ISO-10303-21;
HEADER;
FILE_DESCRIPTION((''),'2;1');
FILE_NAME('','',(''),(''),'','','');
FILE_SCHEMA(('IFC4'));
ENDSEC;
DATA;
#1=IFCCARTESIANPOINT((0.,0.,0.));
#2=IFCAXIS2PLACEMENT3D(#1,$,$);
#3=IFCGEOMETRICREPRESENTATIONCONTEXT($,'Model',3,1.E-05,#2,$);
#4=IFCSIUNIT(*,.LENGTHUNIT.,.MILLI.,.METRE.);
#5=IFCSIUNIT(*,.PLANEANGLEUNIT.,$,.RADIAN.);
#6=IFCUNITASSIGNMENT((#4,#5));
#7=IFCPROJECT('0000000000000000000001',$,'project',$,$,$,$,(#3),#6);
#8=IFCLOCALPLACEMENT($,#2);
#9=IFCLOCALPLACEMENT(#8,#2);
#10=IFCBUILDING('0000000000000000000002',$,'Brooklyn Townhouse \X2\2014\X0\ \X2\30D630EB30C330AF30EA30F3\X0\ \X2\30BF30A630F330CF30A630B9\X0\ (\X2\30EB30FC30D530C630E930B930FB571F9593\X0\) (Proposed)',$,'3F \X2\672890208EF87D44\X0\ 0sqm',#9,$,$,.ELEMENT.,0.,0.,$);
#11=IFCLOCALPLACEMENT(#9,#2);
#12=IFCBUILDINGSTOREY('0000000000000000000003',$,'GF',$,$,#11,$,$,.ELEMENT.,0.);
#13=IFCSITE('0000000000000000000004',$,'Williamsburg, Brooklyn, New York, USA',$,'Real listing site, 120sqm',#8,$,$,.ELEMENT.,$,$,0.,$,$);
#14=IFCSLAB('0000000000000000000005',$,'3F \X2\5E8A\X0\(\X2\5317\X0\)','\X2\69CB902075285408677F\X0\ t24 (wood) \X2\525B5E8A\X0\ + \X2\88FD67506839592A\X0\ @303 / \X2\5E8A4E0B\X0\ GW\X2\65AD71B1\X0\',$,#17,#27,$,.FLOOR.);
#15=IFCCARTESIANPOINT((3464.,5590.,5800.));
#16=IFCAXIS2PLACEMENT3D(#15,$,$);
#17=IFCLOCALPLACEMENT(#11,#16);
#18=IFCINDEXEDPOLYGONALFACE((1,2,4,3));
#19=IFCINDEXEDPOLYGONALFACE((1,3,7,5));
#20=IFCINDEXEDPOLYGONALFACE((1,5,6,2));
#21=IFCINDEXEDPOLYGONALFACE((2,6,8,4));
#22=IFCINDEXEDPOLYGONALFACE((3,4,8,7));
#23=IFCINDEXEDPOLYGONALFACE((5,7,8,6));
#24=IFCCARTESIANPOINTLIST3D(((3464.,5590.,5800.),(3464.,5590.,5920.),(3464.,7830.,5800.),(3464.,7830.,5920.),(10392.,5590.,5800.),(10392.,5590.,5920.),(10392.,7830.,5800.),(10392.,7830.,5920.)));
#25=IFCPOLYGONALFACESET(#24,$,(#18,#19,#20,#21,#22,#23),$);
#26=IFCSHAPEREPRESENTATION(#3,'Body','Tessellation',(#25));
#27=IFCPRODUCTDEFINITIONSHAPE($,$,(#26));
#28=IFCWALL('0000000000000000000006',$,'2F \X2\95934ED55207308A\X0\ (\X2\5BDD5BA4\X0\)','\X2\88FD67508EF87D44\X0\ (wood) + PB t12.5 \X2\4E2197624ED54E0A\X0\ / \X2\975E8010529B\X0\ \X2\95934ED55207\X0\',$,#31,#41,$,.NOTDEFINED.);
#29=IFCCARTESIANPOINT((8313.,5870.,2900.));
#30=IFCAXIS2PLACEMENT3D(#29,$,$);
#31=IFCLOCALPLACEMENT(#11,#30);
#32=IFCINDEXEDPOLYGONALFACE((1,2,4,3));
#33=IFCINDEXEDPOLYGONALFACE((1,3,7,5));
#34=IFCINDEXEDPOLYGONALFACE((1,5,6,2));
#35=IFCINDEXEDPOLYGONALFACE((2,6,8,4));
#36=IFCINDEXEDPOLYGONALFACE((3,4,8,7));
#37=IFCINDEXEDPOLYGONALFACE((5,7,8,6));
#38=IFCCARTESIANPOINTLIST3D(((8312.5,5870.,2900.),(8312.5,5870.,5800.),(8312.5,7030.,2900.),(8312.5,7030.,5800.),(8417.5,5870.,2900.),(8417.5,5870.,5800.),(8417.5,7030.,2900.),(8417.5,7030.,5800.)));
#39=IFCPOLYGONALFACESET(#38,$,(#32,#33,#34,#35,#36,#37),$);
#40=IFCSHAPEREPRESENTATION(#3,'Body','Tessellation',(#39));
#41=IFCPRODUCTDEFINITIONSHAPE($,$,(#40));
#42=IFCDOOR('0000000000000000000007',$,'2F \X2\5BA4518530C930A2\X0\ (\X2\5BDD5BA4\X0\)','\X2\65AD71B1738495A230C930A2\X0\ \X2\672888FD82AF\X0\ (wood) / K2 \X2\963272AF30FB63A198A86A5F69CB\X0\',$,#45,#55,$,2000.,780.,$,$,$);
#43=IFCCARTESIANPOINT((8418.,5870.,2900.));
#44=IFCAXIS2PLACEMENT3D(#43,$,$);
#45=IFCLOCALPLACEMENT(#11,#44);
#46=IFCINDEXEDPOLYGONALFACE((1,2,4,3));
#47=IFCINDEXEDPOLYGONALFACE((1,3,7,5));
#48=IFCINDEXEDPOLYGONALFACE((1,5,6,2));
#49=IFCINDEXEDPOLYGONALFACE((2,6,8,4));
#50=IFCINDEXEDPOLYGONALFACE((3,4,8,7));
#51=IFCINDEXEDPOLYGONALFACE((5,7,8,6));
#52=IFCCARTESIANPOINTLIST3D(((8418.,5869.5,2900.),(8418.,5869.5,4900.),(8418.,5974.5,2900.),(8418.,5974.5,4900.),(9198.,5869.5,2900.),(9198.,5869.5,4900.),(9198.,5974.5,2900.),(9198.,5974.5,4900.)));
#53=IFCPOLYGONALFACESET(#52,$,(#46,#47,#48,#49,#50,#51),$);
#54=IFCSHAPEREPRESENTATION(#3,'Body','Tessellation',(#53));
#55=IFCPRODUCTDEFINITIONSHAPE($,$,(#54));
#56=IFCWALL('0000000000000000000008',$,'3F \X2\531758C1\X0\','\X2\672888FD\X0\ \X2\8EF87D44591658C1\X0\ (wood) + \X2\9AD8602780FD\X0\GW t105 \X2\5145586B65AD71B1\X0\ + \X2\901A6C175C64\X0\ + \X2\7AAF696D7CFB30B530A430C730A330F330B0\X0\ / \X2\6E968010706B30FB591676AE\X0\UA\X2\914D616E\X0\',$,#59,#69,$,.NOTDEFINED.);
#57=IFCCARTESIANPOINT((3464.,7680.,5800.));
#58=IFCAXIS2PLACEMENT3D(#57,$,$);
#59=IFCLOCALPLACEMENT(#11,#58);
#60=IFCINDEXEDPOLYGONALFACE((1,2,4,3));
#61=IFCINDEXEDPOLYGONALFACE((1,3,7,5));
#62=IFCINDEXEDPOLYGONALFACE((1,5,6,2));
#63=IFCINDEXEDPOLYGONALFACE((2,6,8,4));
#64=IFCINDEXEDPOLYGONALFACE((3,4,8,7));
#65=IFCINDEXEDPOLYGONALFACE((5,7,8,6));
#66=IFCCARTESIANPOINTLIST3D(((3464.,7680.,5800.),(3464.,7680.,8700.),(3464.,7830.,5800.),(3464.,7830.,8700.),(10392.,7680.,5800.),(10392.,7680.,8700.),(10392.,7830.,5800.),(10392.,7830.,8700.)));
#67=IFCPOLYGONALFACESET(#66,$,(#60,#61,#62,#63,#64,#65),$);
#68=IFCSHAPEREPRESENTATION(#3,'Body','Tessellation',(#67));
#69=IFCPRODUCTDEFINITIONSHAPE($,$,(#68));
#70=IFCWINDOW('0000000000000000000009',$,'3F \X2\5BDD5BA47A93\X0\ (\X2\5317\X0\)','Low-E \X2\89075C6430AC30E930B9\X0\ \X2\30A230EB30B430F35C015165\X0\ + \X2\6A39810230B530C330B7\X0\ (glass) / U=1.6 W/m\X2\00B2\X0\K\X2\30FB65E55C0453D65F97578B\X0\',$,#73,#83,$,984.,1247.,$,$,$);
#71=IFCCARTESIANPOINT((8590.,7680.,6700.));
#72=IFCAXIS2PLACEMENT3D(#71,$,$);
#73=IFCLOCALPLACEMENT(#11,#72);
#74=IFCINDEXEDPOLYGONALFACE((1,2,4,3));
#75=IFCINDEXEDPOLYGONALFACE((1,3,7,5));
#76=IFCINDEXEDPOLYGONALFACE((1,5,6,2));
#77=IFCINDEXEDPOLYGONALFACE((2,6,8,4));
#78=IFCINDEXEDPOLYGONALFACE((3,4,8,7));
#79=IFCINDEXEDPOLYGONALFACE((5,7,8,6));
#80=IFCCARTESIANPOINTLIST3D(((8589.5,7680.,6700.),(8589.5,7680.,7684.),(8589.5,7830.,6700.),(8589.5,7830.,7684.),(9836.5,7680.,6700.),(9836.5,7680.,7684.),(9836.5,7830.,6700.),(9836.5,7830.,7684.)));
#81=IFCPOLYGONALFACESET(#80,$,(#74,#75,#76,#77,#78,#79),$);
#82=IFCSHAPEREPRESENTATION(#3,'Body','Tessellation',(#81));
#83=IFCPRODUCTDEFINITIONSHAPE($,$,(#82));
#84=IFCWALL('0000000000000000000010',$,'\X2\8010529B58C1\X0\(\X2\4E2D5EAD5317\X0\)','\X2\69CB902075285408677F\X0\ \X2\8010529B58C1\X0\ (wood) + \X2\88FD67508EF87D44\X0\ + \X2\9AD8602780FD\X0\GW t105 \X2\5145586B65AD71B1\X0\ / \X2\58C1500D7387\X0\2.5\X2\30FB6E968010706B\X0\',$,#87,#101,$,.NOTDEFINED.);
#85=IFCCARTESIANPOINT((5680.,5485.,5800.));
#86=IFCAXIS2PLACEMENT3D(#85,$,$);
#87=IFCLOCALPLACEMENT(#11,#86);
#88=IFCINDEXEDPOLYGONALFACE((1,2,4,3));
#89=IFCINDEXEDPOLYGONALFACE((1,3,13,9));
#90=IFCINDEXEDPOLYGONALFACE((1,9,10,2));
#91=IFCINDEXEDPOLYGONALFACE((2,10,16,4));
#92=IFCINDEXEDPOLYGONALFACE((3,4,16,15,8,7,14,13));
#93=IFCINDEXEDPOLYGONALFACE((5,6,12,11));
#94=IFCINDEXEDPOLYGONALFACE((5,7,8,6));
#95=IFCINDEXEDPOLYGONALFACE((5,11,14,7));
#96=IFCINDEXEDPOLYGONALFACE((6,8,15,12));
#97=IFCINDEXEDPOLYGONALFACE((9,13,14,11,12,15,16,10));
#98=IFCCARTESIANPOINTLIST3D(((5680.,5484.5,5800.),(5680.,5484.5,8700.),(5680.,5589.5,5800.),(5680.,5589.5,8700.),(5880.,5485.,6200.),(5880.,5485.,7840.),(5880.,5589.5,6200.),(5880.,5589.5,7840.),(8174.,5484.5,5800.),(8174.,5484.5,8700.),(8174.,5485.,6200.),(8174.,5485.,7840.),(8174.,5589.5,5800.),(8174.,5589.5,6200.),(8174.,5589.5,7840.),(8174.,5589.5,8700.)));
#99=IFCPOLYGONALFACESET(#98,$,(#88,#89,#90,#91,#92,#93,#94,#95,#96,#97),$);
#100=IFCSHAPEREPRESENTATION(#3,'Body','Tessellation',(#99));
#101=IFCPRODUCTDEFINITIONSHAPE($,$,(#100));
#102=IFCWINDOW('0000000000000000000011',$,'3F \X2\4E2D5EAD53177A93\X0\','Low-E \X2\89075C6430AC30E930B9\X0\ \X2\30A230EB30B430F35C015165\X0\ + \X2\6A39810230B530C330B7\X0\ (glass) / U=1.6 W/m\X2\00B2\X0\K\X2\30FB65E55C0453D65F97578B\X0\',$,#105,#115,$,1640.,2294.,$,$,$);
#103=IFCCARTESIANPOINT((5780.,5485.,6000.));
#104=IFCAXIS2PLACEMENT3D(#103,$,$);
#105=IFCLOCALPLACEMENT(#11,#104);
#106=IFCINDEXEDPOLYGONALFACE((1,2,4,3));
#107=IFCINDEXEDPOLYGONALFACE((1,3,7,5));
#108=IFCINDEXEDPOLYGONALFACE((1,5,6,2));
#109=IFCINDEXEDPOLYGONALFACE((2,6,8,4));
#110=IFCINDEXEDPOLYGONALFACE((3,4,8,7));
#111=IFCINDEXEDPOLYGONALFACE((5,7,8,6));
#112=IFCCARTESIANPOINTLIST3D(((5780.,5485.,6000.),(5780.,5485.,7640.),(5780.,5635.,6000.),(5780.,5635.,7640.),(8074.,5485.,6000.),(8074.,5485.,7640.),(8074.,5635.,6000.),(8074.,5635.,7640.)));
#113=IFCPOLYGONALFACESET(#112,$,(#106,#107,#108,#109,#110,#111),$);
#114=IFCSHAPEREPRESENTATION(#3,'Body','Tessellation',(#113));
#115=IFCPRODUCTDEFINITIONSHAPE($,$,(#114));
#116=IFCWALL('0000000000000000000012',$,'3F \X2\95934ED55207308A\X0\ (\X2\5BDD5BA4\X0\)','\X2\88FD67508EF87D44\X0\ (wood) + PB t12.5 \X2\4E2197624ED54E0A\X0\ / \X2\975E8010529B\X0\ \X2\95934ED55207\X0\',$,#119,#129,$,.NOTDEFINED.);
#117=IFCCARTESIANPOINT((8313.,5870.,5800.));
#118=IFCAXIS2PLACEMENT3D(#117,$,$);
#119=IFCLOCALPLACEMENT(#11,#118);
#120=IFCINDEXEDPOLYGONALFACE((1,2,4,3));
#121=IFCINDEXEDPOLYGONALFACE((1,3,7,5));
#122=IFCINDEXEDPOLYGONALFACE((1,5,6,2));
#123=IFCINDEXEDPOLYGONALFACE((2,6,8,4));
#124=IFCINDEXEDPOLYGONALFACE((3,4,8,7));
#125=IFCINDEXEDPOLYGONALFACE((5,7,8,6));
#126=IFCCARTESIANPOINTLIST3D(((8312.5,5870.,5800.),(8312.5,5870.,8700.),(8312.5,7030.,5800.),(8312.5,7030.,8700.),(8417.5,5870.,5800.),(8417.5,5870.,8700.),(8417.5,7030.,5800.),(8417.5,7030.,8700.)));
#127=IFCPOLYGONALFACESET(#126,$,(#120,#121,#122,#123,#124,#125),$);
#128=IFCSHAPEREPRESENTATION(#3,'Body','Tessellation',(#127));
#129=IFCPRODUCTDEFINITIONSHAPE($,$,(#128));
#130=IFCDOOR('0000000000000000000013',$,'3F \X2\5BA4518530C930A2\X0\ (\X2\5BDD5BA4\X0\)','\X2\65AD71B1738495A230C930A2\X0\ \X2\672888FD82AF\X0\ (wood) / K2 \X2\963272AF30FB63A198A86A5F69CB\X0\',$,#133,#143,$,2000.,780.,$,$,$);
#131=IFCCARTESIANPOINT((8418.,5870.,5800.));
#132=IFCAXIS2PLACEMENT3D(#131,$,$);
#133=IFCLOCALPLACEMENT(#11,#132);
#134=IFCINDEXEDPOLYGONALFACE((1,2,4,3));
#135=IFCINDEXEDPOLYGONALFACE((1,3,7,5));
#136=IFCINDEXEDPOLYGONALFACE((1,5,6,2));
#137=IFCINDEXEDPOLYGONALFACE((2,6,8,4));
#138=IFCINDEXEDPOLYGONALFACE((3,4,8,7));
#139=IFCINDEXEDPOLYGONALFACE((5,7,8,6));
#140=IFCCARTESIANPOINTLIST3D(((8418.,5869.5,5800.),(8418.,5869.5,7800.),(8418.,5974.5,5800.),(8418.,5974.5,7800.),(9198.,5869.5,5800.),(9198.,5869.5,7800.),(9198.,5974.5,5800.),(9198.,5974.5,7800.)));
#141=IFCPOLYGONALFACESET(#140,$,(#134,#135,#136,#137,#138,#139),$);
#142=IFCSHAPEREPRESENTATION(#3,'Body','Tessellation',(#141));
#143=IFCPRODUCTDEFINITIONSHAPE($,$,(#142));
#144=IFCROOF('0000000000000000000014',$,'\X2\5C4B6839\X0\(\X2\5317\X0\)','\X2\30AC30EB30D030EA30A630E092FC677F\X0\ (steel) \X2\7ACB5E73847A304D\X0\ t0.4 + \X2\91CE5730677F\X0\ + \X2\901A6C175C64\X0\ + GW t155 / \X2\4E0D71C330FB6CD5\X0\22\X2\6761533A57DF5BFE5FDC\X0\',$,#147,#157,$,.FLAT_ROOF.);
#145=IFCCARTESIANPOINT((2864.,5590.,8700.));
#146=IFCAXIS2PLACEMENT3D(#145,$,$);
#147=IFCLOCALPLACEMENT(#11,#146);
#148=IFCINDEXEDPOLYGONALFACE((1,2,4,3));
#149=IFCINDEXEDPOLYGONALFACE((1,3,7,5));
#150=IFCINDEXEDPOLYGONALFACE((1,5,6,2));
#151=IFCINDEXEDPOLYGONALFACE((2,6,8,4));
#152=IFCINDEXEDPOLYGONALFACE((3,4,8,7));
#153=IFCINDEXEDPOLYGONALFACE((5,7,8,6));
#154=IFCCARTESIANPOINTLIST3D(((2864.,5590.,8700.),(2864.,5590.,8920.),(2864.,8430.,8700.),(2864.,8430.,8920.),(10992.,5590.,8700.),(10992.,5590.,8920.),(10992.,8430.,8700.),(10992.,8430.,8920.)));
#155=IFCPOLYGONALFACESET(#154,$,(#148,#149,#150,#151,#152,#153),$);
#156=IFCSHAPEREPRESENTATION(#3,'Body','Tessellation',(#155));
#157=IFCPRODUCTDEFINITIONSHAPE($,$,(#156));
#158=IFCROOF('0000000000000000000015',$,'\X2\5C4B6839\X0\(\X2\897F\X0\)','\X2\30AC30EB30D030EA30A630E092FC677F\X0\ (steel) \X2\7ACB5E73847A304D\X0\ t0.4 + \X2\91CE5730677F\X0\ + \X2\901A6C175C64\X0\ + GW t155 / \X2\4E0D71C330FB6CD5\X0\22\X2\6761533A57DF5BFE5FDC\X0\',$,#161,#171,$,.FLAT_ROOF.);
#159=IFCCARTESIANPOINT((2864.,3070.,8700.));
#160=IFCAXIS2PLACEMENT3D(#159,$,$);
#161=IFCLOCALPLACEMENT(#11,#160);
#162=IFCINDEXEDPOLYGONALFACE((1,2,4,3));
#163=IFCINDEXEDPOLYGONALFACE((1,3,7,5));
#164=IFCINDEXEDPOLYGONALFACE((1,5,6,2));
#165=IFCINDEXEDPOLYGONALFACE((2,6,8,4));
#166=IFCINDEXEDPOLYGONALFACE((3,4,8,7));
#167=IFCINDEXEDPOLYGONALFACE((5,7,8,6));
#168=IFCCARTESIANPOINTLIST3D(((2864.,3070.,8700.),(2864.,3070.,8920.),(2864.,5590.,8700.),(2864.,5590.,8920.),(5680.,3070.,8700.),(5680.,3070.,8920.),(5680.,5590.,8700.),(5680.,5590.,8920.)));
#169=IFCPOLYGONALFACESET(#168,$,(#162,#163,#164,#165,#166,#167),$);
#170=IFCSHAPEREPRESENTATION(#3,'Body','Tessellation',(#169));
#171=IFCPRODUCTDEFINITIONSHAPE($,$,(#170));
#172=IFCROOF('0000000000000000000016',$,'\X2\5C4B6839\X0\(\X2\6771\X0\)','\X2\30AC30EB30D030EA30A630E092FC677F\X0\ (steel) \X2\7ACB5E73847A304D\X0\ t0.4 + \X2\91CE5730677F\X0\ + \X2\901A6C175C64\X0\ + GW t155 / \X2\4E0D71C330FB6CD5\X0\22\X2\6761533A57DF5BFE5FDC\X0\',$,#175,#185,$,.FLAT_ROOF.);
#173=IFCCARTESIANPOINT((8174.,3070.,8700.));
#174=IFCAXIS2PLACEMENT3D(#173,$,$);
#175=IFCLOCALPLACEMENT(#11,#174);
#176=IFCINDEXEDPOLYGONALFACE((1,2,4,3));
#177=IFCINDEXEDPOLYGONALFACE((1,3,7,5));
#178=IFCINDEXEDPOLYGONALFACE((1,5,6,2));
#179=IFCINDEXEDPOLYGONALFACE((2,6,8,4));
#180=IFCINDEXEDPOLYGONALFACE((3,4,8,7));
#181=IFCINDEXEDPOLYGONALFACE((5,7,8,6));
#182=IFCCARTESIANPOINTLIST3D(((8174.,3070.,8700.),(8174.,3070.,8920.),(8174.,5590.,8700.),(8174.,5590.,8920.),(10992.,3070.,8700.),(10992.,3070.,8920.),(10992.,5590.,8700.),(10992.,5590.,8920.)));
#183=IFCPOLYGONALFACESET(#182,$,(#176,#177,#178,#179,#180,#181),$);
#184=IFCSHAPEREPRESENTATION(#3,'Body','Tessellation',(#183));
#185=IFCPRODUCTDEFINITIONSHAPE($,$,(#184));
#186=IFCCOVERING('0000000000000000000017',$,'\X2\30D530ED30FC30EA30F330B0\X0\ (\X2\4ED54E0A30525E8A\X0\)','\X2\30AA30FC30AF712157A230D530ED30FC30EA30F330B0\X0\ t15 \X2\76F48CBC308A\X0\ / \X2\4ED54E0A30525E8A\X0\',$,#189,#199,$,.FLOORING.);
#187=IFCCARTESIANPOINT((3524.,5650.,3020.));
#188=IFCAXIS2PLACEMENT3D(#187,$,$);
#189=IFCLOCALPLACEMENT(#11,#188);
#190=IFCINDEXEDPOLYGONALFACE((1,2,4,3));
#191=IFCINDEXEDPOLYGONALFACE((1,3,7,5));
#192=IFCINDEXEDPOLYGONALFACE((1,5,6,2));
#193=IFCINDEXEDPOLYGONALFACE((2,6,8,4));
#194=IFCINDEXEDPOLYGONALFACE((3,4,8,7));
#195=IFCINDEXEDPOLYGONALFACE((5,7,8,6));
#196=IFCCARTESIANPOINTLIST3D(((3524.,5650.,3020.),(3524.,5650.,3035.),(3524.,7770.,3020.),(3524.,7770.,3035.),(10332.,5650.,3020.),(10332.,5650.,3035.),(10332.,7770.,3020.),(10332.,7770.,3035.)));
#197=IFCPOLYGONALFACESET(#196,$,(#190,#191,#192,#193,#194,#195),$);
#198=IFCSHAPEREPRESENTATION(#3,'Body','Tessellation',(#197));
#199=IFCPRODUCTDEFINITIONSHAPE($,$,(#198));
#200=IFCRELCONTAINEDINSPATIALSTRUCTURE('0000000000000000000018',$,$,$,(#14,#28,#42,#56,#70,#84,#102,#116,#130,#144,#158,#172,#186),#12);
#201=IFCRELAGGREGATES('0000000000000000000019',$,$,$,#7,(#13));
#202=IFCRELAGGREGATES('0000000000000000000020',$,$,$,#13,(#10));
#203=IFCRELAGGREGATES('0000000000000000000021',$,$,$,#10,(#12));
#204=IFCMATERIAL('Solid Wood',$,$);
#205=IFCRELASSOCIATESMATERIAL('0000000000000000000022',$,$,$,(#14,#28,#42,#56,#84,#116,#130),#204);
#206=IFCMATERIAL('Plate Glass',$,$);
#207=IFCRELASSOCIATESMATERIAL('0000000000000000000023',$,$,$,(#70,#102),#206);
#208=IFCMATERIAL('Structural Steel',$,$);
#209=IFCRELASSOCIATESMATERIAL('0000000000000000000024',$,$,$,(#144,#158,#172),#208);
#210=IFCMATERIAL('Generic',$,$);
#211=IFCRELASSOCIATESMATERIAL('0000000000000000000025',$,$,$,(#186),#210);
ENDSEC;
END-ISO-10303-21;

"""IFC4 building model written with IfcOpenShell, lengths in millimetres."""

from ifc_helpers import new_model, si_unit, frame, frame_2d, origin, place, context, project, spatial, rectangle, extrude, material, element, fill, save


model = new_model("IFC4")

# Units and contexts
model_context = context("Model", 3, precision=1e-05, world=origin())
ifc_project = project(units=[si_unit("LENGTHUNIT", "METRE", prefix="MILLI"), si_unit("PLANEANGLEUNIT", "RADIAN")], contexts=[model_context])

# Site, building, storey
site_placement = place(None, origin())
site = spatial("IfcSite", under=ifc_project, at=site_placement, Name="Williamsburg, Brooklyn, New York, USA", ObjectType="Real listing site, 120sqm", CompositionType="ELEMENT", RefElevation=0.0)
building_placement = place(site_placement, origin())
building = spatial("IfcBuilding", under=site, at=building_placement, Name="Brooklyn Townhouse — ブルックリン タウンハウス (ルーフテラス・土間) (Proposed)", ObjectType="3F 木造軸組 0sqm", CompositionType="ELEMENT", ElevationOfRefHeight=0.0, ElevationOfTerrain=0.0)
storey_placement = place(building_placement, origin())
storey = spatial("IfcBuildingStorey", under=building, at=storey_placement, Name="GF", CompositionType="ELEMENT", Elevation=0.0)

# Slab
ifc_material_1 = material(Name="Solid Wood")
slab_placement = place(storey_placement, frame((3464.0, 5590.0, 5800.0)))
element("IfcSlab", 1, at=slab_placement, inside=storey, material=ifc_material_1, Name="3F 床(北)", Description="構造用合板 t24 (wood) 剛床 + 製材根太 @303 / 床下 GW断熱", PredefinedType="FLOOR", context=model_context, shape_type="SweptSolid", body=[
    extrude(rectangle(XDim=6928.0, YDim=2240.0, at=frame_2d((3464.0, 1120.0))), frame((3464.0, 5590.0, 5800.0)), (0.0, 0.0, 1.0), 120.0),
])

# Wall
wall_1_placement = place(storey_placement, frame((8313.0, 5870.0, 2900.0)))
element("IfcWall", 2, at=wall_1_placement, inside=storey, material=ifc_material_1, Name="2F 間仕切り (寝室)", Description="製材軸組 (wood) + PB t12.5 両面仕上 / 非耐力 間仕切", PredefinedType="NOTDEFINED", context=model_context, shape_type="SweptSolid", body=[
    extrude(rectangle(XDim=105.0, YDim=1160.0, at=frame_2d((52.0, 580.0))), frame((8313.0, 5870.0, 2900.0)), (0.0, 0.0, 1.0), 2900.0),
])

# Door
door_1_placement = place(storey_placement, frame((8418.0, 5870.0, 2900.0)))
element("IfcDoor", 3, at=door_1_placement, inside=storey, material=ifc_material_1, Name="2F 室内ドア (寝室)", Description="断熱玄関ドア 木製芯 (wood) / K2 防犯・採風機構", OverallHeight=2000.0, OverallWidth=780.0, context=model_context, shape_type="SweptSolid", body=[
    extrude(rectangle(XDim=780.0, YDim=105.0, at=frame_2d((390.0, 52.0))), frame((8418.0, 5870.0, 2900.0)), (0.0, 0.0, 1.0), 2000.0),
])

# Walls, openings, windows
wall_2_placement = place(storey_placement, frame((3464.0, 7680.0, 5800.0)))
wall_2 = element("IfcWall", 4, at=wall_2_placement, inside=storey, material=ifc_material_1, Name="3F 北壁", Description="木製 軸組外壁 (wood) + 高性能GW t105 充填断熱 + 通気層 + 窯業系サイディング / 準耐火・外皮UA配慮", PredefinedType="NOTDEFINED", context=model_context, shape_type="SweptSolid", body=[
    extrude(rectangle(XDim=6928.0, YDim=150.0, at=frame_2d((3464.0, 75.0))), frame((3464.0, 7680.0, 5800.0)), (0.0, 0.0, 1.0), 2900.0),
])
opening_1_placement = place(storey_placement, frame((8590.0, 7680.0, 6700.0)))
opening_1 = element("IfcOpeningElement", 5, at=opening_1_placement, cuts=wall_2, PredefinedType="NOTDEFINED", context=model_context, shape_type="SweptSolid", body=[
    extrude(rectangle(XDim=1247.0, YDim=150.0, at=frame_2d((623.0, 75.0))), frame((8590.0, 7680.0, 6700.0)), (0.0, 0.0, 1.0), 984.0),
])
ifc_material_2 = material(Name="Plate Glass")
window_1_placement = place(storey_placement, frame((8590.0, 7680.0, 6700.0)))
window_1 = element("IfcWindow", 6, at=window_1_placement, inside=storey, material=ifc_material_2, Name="3F 寝室窓 (北)", Description="Low-E 複層ガラス アルゴン封入 + 樹脂サッシ (glass) / U=1.6 W/m²K・日射取得型", OverallHeight=984.0, OverallWidth=1247.0, context=model_context, shape_type="SweptSolid", body=[
    extrude(rectangle(XDim=1247.0, YDim=150.0, at=frame_2d((623.0, 75.0))), frame((8590.0, 7680.0, 6700.0)), (0.0, 0.0, 1.0), 984.0),
])
fill(opening_1, window_1)
wall_3_placement = place(storey_placement, frame((5680.0, 5485.0, 5800.0)))
wall_3 = element("IfcWall", 7, at=wall_3_placement, inside=storey, material=ifc_material_1, Name="耐力壁(中庭北)", Description="構造用合板 耐力壁 (wood) + 製材軸組 + 高性能GW t105 充填断熱 / 壁倍率2.5・準耐火", PredefinedType="NOTDEFINED", context=model_context, shape_type="SweptSolid", body=[
    extrude(rectangle(XDim=2494.0, YDim=105.0, at=frame_2d((1247.0, 52.0))), frame((5680.0, 5485.0, 5800.0)), (0.0, 0.0, 1.0), 2900.0),
])
opening_2_placement = place(storey_placement, frame((5780.0, 5485.0, 6000.0)))
opening_2 = element("IfcOpeningElement", 8, at=opening_2_placement, cuts=wall_3, PredefinedType="NOTDEFINED", context=model_context, shape_type="SweptSolid", body=[
    extrude(rectangle(XDim=2294.0, YDim=150.0, at=frame_2d((1147.0, 75.0))), frame((5780.0, 5485.0, 6000.0)), (0.0, 0.0, 1.0), 1640.0),
])
window_2_placement = place(storey_placement, frame((5780.0, 5485.0, 6000.0)))
window_2 = element("IfcWindow", 9, at=window_2_placement, inside=storey, material=ifc_material_2, Name="3F 中庭北窓", Description="Low-E 複層ガラス アルゴン封入 + 樹脂サッシ (glass) / U=1.6 W/m²K・日射取得型", OverallHeight=1640.0, OverallWidth=2294.0, context=model_context, shape_type="SweptSolid", body=[
    extrude(rectangle(XDim=2294.0, YDim=150.0, at=frame_2d((1147.0, 75.0))), frame((5780.0, 5485.0, 6000.0)), (0.0, 0.0, 1.0), 1640.0),
])
fill(opening_2, window_2)

# Wall
wall_4_placement = place(storey_placement, frame((8313.0, 5870.0, 5800.0)))
element("IfcWall", 10, at=wall_4_placement, inside=storey, material=ifc_material_1, Name="3F 間仕切り (寝室)", Description="製材軸組 (wood) + PB t12.5 両面仕上 / 非耐力 間仕切", PredefinedType="NOTDEFINED", context=model_context, shape_type="SweptSolid", body=[
    extrude(rectangle(XDim=105.0, YDim=1160.0, at=frame_2d((52.0, 580.0))), frame((8313.0, 5870.0, 5800.0)), (0.0, 0.0, 1.0), 2900.0),
])

# Door
door_2_placement = place(storey_placement, frame((8418.0, 5870.0, 5800.0)))
element("IfcDoor", 11, at=door_2_placement, inside=storey, material=ifc_material_1, Name="3F 室内ドア (寝室)", Description="断熱玄関ドア 木製芯 (wood) / K2 防犯・採風機構", OverallHeight=2000.0, OverallWidth=780.0, context=model_context, shape_type="SweptSolid", body=[
    extrude(rectangle(XDim=780.0, YDim=105.0, at=frame_2d((390.0, 52.0))), frame((8418.0, 5870.0, 5800.0)), (0.0, 0.0, 1.0), 2000.0),
])

# Roofs
ifc_material_3 = material(Name="Structural Steel")
for number, where, name in (
    (12, (2864.0, 5590.0, 8700.0), "屋根(北)"),
):
    element("IfcRoof", number, at=place(storey_placement, frame(where)), inside=storey, material=ifc_material_3, Name=name, Description="ガルバリウム鋼板 (steel) 立平葺き t0.4 + 野地板 + 通気層 + GW t155 / 不燃・法22条区域対応", PredefinedType="FLAT_ROOF", context=model_context, shape_type="SweptSolid", body=[
        extrude(rectangle(XDim=8128.0, YDim=2840.0, at=frame_2d((4064.0, 1420.0))), frame((2864.0, 5590.0, 8700.0)), (0.0, 0.0, 1.0), 220.0),
    ])
roof_1_placement = place(storey_placement, frame((2864.0, 3070.0, 8700.0)))
element("IfcRoof", 13, at=roof_1_placement, inside=storey, material=ifc_material_3, Name="屋根(西)", Description="ガルバリウム鋼板 (steel) 立平葺き t0.4 + 野地板 + 通気層 + GW t155 / 不燃・法22条区域対応", PredefinedType="FLAT_ROOF", context=model_context, shape_type="SweptSolid", body=[
    extrude(rectangle(XDim=2816.0, YDim=2520.0, at=frame_2d((1408.0, 1260.0))), frame((2864.0, 3070.0, 8700.0)), (0.0, 0.0, 1.0), 220.0),
])
roof_2_placement = place(storey_placement, frame((8174.0, 3070.0, 8700.0)))
element("IfcRoof", 14, at=roof_2_placement, inside=storey, material=ifc_material_3, Name="屋根(東)", Description="ガルバリウム鋼板 (steel) 立平葺き t0.4 + 野地板 + 通気層 + GW t155 / 不燃・法22条区域対応", PredefinedType="FLAT_ROOF", context=model_context, shape_type="SweptSolid", body=[
    extrude(rectangle(XDim=2818.0, YDim=2520.0, at=frame_2d((1409.0, 1260.0))), frame((8174.0, 3070.0, 8700.0)), (0.0, 0.0, 1.0), 220.0),
])

# Covering
ifc_material_4 = material(Name="Generic")
covering_1_placement = place(storey_placement, frame((3524.0, 5650.0, 3020.0)))
element("IfcCovering", 15, at=covering_1_placement, inside=storey, material=ifc_material_4, Name="フローリング (仕上げ床)", Description="オーク無垢フローリング t15 直貼り / 仕上げ床", PredefinedType="FLOORING", context=model_context, shape_type="SweptSolid", body=[
    extrude(rectangle(XDim=6808.0, YDim=2120.0, at=frame_2d((3404.0, 1060.0))), frame((3524.0, 5650.0, 3020.0)), (0.0, 0.0, 1.0), 15.0),
])

save(model, "model.ifc")
